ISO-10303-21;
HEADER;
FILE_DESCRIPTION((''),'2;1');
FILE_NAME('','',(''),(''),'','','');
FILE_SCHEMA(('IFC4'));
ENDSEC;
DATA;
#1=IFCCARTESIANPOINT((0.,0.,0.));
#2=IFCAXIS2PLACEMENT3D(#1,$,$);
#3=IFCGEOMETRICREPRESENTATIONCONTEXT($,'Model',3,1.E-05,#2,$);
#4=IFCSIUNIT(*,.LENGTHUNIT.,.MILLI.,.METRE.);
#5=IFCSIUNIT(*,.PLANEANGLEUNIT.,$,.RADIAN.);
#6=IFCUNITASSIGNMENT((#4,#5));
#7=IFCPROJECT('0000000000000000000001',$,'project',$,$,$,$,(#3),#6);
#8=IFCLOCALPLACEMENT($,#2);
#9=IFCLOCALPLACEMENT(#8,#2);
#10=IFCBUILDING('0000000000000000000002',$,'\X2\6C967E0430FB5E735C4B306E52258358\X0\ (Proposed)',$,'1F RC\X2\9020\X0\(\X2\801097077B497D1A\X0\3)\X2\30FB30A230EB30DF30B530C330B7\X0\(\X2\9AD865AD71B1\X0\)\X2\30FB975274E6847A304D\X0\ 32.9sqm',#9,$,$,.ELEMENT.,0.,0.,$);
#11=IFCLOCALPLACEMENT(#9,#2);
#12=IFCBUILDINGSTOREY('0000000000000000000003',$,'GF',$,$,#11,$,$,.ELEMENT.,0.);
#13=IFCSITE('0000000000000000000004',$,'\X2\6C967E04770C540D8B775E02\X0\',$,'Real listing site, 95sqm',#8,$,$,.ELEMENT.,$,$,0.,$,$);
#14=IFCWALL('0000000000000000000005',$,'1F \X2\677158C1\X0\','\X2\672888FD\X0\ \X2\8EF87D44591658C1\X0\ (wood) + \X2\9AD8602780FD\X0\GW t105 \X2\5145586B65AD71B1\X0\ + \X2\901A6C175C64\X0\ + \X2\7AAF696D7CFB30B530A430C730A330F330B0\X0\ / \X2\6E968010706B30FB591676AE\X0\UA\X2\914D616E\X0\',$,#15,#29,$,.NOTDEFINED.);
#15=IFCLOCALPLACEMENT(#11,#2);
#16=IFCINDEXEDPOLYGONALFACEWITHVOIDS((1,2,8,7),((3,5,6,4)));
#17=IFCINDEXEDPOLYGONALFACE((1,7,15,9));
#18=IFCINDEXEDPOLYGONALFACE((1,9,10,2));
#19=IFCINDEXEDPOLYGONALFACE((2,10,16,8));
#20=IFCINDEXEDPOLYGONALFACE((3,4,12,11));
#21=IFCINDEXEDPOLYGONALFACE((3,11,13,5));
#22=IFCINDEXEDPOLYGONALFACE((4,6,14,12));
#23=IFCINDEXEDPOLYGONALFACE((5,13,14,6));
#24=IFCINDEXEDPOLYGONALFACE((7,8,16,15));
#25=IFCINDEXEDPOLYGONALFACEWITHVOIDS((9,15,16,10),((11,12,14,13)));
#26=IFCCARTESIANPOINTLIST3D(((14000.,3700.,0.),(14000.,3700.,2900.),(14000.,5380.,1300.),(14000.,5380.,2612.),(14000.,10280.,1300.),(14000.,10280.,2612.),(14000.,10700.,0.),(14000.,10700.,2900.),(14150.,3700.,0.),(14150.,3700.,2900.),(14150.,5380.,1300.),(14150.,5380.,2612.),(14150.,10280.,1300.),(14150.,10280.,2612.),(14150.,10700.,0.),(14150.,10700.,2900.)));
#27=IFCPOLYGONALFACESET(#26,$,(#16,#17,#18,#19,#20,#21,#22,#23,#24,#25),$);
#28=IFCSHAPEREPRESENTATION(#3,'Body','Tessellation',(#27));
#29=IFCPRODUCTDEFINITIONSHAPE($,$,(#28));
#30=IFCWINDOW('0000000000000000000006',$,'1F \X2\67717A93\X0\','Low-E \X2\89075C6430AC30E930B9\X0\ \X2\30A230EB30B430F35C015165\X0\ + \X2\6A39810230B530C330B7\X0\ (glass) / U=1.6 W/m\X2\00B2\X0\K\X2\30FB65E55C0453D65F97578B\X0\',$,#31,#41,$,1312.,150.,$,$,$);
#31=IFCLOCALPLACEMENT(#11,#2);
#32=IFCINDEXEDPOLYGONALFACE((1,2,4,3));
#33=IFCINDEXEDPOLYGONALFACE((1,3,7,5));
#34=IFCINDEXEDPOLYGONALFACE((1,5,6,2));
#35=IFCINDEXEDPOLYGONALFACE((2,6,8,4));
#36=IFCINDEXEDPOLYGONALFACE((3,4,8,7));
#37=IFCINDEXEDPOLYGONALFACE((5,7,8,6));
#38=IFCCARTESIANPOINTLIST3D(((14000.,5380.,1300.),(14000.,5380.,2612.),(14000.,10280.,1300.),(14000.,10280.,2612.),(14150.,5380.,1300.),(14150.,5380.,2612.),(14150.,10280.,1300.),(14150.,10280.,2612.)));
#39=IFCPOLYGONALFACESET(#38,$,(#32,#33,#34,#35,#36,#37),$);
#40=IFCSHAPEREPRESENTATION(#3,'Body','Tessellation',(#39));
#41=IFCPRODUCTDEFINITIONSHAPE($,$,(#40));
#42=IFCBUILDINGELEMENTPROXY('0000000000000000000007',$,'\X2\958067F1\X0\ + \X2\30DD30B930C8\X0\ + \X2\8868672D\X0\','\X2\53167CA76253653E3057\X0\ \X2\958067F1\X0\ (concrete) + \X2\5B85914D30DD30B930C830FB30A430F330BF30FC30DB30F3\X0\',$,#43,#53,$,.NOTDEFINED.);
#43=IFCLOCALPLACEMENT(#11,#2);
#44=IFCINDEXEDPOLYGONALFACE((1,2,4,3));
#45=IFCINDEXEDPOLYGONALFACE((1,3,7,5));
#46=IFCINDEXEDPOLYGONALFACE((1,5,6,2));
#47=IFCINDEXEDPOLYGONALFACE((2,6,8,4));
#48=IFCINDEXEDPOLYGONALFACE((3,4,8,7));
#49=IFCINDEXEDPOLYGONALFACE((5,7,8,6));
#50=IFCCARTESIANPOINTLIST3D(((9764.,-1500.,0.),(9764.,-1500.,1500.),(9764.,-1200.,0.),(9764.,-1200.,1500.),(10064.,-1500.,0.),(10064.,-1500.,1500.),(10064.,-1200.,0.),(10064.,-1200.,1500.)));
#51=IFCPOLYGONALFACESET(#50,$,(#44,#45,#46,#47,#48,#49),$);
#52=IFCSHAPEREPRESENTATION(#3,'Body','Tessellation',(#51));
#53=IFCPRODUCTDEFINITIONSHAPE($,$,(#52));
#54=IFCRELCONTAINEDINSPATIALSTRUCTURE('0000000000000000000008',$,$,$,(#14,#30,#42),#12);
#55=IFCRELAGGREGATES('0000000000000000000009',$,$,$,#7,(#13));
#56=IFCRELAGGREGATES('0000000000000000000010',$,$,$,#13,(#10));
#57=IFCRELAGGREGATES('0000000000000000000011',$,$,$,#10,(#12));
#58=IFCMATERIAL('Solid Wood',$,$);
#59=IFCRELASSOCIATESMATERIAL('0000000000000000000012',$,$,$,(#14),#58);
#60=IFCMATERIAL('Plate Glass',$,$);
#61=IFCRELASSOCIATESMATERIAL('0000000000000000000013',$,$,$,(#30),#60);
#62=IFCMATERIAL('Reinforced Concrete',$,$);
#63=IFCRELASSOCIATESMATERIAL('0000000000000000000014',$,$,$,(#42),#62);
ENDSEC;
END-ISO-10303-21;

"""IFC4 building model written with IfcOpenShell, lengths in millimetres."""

from ifc_helpers import new_model, si_unit, frame, frame_2d, origin, place, context, project, spatial, rectangle, extrude, material, element, fill, save


model = new_model("IFC4")

# Units and contexts
model_context = context("Model", 3, precision=1e-05, world=origin())
ifc_project = project(units=[si_unit("LENGTHUNIT", "METRE", prefix="MILLI"), si_unit("PLANEANGLEUNIT", "RADIAN")], contexts=[model_context])

# Site, building, storey
site_placement = place(None, origin())
site = spatial("IfcSite", under=ifc_project, at=site_placement, Name="沖縄県名護市", ObjectType="Real listing site, 95sqm", CompositionType="ELEMENT", RefElevation=0.0)
building_placement = place(site_placement, origin())
building = spatial("IfcBuilding", under=site, at=building_placement, Name="沖縄・平屋の別荘 (Proposed)", ObjectType="1F RC造(耐震等級3)・アルミサッシ(高断熱)・青瓦葺き 32.9sqm", CompositionType="ELEMENT", ElevationOfRefHeight=0.0, ElevationOfTerrain=0.0)
storey_placement = place(building_placement, origin())
storey = spatial("IfcBuildingStorey", under=building, at=storey_placement, Name="GF", CompositionType="ELEMENT", Elevation=0.0)

# Shared definitions
ifc_material_1 = material(Name="Solid Wood")

# Shared definitions
ifc_material_2 = material(Name="Reinforced Concrete")

# Shared definitions
ifc_material_3 = material(Name="Plate Glass")

# Wall, opening, window
wall_1_placement = place(storey_placement, frame((7000.0, 1850.0, 0.0)))
wall_1 = element("IfcWall", 1, at=wall_1_placement, inside=storey, material=ifc_material_1, Name="1F 東壁", Description="木製 軸組外壁 (wood) + 高性能GW t105 充填断熱 + 通気層 + 窯業系サイディング / 準耐火・外皮UA配慮", PredefinedType="NOTDEFINED", context=model_context, shape_type="SweptSolid", body=[
    extrude(rectangle(XDim=150.0, YDim=7000.0, at=frame_2d((75.0, 3500.0))), frame((7000.0, 1850.0, 0.0)), (0.0, 0.0, 1.0), 2900.0),
])
opening_1_placement = place(storey_placement, frame((7000.0, 2690.0, 650.0)))
opening_1 = element("IfcOpeningElement", 2, at=opening_1_placement, cuts=wall_1, PredefinedType="NOTDEFINED", context=model_context, shape_type="SweptSolid", body=[
    extrude(rectangle(XDim=150.0, YDim=4900.0, at=frame_2d((75.0, 2450.0))), frame((7000.0, 2690.0, 650.0)), (0.0, 0.0, 1.0), 1312.0),
])
window_1_placement = place(storey_placement, frame((7000.0, 2690.0, 650.0)))
window_1 = element("IfcWindow", 3, at=window_1_placement, inside=storey, material=ifc_material_3, Name="1F 東窓", Description="Low-E 複層ガラス アルゴン封入 + 樹脂サッシ (glass) / U=1.6 W/m²K・日射取得型", OverallHeight=1312.0, OverallWidth=150.0, context=model_context, shape_type="SweptSolid", body=[
    extrude(rectangle(XDim=150.0, YDim=4900.0, at=frame_2d((75.0, 2450.0))), frame((7000.0, 2690.0, 650.0)), (0.0, 0.0, 1.0), 1312.0),
])
fill(opening_1, window_1)

# Building element proxy
proxy_placement = place(storey_placement, frame((4882.0, -750.0, 0.0)))
element("IfcBuildingElementProxy", 4, at=proxy_placement, inside=storey, material=ifc_material_2, Name="門柱 + ポスト + 表札", Description="化粧打放し 門柱 (concrete) + 宅配ポスト・インターホン", PredefinedType="NOTDEFINED", context=model_context, shape_type="SweptSolid", body=[
    extrude(rectangle(XDim=300.0, YDim=300.0, at=frame_2d((150.0, 150.0))), frame((4882.0, -750.0, 0.0)), (0.0, 0.0, 1.0), 1500.0),
])

save(model, "model.ifc")
